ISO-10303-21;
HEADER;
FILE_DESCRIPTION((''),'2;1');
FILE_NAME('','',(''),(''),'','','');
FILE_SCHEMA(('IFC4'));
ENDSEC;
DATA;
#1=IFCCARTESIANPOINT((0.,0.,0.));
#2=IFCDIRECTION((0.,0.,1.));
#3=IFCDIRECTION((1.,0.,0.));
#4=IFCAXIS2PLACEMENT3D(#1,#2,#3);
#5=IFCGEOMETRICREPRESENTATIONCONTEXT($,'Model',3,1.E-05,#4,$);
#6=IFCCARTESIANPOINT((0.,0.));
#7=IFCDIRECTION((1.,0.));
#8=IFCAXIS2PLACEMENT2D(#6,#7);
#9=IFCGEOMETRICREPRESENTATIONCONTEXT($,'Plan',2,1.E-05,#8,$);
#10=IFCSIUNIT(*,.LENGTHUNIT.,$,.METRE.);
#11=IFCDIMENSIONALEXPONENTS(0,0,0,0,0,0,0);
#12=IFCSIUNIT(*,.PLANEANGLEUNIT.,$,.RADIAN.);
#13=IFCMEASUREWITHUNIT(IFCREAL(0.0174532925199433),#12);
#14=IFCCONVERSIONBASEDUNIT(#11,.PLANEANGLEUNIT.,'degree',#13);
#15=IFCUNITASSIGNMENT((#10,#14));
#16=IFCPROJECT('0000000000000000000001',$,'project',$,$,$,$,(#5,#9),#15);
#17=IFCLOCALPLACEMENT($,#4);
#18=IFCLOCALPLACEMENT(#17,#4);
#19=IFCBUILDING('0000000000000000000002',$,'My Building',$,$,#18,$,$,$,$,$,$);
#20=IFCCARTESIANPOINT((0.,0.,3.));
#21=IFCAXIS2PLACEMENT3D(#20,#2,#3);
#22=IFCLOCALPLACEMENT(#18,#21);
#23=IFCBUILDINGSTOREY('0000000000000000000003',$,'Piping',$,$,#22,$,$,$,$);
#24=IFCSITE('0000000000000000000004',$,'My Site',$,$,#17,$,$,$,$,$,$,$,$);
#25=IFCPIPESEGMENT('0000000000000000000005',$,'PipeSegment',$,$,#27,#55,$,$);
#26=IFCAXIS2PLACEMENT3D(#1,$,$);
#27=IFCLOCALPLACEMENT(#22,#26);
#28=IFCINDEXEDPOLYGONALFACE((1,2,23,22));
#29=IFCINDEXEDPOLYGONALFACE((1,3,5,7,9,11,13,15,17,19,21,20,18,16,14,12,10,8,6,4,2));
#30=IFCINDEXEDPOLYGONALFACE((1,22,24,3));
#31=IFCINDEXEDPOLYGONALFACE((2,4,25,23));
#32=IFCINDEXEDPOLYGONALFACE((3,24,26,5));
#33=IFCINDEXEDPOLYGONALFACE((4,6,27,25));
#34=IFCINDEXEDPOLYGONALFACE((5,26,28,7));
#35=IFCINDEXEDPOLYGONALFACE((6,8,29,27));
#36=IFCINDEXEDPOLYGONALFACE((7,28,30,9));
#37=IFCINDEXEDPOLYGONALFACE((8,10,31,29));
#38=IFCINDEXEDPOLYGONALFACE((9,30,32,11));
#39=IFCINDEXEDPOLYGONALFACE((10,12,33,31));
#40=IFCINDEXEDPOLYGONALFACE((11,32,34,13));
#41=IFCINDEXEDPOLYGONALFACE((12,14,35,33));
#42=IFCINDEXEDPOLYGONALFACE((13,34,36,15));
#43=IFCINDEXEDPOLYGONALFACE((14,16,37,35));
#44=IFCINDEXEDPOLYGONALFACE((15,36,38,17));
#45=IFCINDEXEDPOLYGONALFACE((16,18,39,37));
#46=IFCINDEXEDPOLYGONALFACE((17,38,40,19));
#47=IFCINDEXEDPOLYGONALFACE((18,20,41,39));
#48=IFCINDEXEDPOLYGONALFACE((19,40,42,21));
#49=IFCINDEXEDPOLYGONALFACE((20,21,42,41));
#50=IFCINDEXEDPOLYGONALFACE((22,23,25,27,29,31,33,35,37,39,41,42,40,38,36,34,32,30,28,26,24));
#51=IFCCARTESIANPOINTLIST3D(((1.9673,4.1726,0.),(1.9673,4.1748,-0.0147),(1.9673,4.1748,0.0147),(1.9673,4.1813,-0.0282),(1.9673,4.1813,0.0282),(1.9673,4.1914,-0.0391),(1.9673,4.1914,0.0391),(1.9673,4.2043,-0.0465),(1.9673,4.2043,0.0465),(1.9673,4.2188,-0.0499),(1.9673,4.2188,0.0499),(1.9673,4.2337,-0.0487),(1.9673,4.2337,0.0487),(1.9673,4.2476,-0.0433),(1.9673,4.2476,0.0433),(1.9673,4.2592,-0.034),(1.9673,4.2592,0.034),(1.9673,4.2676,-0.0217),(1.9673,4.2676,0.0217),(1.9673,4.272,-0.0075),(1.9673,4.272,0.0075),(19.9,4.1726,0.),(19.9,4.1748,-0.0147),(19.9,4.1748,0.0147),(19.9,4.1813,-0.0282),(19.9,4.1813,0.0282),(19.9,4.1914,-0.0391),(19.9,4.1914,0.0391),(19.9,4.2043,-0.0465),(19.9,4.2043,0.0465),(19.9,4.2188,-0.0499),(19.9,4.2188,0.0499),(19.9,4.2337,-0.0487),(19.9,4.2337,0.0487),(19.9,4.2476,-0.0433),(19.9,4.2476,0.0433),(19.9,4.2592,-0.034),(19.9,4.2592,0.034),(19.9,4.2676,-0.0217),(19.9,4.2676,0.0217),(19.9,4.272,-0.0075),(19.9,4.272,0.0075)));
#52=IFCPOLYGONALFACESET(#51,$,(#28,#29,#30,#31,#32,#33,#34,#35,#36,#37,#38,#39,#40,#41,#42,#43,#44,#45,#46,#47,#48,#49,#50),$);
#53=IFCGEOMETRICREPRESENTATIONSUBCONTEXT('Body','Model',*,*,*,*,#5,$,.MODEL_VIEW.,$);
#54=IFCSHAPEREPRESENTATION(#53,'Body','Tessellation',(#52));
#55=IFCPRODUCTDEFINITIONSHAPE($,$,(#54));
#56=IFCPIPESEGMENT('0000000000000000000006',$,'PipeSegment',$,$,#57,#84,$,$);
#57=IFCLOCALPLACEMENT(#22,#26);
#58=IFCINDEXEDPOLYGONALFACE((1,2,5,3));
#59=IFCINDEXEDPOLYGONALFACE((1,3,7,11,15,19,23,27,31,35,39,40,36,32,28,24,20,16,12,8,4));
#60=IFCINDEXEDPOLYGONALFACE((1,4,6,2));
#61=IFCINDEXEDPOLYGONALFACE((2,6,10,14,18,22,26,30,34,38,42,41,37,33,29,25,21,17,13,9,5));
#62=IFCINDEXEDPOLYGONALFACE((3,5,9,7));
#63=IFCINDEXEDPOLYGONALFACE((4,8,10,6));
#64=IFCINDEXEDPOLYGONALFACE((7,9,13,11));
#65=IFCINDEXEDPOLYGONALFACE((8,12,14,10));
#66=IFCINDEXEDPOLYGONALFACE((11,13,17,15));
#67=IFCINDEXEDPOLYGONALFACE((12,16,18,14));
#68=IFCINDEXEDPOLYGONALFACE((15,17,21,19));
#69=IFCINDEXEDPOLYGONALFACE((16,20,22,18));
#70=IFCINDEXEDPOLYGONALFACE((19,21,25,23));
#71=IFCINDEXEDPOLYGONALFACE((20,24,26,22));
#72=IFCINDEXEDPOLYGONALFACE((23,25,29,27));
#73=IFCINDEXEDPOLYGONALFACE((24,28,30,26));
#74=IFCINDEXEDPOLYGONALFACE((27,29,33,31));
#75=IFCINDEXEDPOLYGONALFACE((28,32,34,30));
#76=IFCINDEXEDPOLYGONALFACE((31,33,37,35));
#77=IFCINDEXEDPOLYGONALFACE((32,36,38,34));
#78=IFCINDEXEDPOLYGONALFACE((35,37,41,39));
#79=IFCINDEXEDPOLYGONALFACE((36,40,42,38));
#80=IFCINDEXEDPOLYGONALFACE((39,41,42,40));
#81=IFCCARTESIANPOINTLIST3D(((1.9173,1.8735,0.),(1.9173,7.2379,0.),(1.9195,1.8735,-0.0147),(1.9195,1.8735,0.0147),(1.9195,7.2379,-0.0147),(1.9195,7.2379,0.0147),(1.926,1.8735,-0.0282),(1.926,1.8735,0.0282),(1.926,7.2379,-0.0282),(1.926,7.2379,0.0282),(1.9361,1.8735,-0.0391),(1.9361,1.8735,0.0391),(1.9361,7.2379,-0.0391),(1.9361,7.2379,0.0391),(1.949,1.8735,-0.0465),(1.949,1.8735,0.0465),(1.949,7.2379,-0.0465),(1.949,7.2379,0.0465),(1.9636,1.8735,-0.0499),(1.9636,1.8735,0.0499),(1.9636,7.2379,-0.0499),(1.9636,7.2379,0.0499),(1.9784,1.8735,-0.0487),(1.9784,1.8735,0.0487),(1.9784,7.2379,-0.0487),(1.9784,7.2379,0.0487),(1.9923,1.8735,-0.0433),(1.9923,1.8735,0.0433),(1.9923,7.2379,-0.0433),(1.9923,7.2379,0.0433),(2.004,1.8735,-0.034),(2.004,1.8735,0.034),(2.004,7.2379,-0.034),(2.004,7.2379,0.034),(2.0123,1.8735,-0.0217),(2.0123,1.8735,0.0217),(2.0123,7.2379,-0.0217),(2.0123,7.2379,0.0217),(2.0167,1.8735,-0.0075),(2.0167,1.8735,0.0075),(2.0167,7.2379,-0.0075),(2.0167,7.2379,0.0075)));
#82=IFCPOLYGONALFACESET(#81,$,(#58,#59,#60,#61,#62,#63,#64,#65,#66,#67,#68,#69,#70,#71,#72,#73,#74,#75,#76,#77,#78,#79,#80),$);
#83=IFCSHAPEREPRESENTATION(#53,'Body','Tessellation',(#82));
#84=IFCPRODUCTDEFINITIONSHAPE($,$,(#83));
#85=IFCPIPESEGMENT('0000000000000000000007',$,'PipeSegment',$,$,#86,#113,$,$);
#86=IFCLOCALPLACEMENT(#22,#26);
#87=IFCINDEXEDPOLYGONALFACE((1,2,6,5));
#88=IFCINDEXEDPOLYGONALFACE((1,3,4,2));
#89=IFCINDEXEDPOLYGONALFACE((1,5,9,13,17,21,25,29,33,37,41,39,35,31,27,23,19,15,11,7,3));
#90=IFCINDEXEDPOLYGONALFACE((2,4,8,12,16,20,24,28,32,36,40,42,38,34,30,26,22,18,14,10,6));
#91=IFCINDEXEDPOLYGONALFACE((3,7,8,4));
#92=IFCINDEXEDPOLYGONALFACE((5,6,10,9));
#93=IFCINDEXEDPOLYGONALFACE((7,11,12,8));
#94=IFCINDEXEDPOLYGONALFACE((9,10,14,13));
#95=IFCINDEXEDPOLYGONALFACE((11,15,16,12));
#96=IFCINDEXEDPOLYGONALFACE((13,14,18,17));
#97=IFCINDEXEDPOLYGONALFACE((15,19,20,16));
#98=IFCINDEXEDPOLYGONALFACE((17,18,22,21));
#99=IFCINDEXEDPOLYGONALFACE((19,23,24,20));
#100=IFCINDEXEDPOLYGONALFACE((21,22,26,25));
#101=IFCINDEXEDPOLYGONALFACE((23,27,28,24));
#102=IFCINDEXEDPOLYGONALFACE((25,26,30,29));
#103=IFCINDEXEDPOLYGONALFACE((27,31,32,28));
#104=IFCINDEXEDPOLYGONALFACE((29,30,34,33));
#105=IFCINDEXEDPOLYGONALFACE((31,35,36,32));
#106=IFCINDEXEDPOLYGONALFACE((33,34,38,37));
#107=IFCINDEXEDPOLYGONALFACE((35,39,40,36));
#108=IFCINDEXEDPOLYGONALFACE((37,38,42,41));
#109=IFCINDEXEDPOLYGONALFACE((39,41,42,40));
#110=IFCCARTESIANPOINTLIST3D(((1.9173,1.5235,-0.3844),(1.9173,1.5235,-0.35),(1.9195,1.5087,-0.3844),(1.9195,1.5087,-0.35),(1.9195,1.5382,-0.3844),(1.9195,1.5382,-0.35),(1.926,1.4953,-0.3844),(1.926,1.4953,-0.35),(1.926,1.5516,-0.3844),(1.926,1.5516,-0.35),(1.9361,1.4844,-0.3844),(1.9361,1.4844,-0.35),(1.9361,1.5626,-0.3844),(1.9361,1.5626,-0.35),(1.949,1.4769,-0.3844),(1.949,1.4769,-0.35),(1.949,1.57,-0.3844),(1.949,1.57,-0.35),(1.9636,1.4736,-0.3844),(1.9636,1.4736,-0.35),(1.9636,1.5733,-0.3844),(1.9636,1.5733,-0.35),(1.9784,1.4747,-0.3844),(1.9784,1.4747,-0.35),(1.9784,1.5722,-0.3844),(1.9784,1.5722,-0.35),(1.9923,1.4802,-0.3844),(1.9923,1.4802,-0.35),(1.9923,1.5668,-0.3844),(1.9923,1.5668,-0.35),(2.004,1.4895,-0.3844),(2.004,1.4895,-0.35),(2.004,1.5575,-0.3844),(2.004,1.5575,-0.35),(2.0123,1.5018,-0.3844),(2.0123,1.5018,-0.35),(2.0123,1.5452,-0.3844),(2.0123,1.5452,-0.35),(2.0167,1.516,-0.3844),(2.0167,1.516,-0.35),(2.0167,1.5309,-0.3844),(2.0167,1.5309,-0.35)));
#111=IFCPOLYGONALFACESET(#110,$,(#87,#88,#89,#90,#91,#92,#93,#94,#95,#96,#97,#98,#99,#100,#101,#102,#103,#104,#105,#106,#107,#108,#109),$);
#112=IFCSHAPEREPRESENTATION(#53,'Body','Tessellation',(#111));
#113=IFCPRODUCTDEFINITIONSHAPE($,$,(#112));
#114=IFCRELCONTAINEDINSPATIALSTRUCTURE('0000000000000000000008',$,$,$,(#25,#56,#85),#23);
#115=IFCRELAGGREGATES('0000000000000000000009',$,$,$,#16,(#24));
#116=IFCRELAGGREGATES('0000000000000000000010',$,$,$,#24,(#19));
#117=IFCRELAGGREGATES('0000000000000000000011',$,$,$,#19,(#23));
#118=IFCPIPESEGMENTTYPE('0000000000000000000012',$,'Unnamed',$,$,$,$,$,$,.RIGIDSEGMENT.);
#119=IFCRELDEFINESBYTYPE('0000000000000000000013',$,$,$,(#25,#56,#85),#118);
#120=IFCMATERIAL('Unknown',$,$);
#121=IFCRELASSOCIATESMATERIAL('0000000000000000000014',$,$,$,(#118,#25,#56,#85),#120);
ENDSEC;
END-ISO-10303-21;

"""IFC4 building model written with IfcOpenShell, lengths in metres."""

from ifc_helpers import new_model, entity, si_unit, converted_unit, frame, origin_with_axes, origin_2d_with_axis, place, context, subcontext, project, spatial, circle, extrude, material, material_profile, profile_set, profile_usage, type_object, element, save


model = new_model("IFC4")

# Units and contexts
model_context = context("Model", 3, precision=1e-05, world=origin_with_axes())
plan_context = context("Plan", 2, precision=1e-05, world=origin_2d_with_axis())
body_context = subcontext(model_context, "Body", "Model", "MODEL_VIEW")
ifc_project = project(units=[si_unit("LENGTHUNIT", "METRE"), converted_unit("PLANEANGLEUNIT", "degree", entity("IfcReal", 0.0174532925199433), si_unit("PLANEANGLEUNIT", "RADIAN"), dimensions=[0, 0, 0, 0, 0, 0, 0])], contexts=[model_context, plan_context])

# Site, building, storey
site_placement = place(None, origin_with_axes())
site = spatial("IfcSite", under=ifc_project, at=site_placement, Name="My Site")
building_placement = place(site_placement, origin_with_axes())
building = spatial("IfcBuilding", under=site, at=building_placement, Name="My Building")
storey_placement = place(building_placement, frame((0.0, 0.0, 3.0), z_axis=(0.0, 0.0, 1.0), x_axis=(1.0, 0.0, 0.0)))
storey = spatial("IfcBuildingStorey", under=building, at=storey_placement, Name="Piping")

# Pipe segments
ifc_material = material(Name="Unknown")
ifc_material_profile = material_profile(ifc_material, circle(Radius=0.05))
ifc_profile_set = profile_set([ifc_material_profile])
ifc_profile_usage_1 = profile_usage(ifc_profile_set, cardinal=5)
pipe_segment_type = type_object("IfcPipeSegmentType", Name="Unnamed", PredefinedType="RIGIDSEGMENT", material=ifc_profile_set)
pipe_segment_1_placement = place(storey_placement, frame((19.9, 4.2226, 0.0), z_axis=(-1.0, 0.0, 0.0), x_axis=(0.0, -1.0, 0.0)))
element("IfcPipeSegment", 1, at=pipe_segment_1_placement, inside=storey, type_object=pipe_segment_type, material=ifc_profile_usage_1, Name="PipeSegment", context=body_context, shape_type="SweptSolid", body=[
    extrude(circle(Radius=0.05), origin_with_axes(), (0.0, 0.0, 1.0), 17.9327),
])
ifc_profile_usage_2 = profile_usage(ifc_profile_set, cardinal=5)
pipe_segment_2_placement = place(storey_placement, frame((1.9673, 1.8735, 0.0), z_axis=(0.0, 1.0, 0.0), x_axis=(-1.0, 0.0, 0.0)))
element("IfcPipeSegment", 2, at=pipe_segment_2_placement, inside=storey, type_object=pipe_segment_type, material=ifc_profile_usage_2, Name="PipeSegment", context=body_context, shape_type="SweptSolid", body=[
    extrude(circle(Radius=0.05), origin_with_axes(), (0.0, 0.0, 1.0), 5.3645),
])
ifc_profile_usage_3 = profile_usage(ifc_profile_set, cardinal=5)
pipe_segment_3_placement = place(storey_placement, frame((1.9673, 1.5235, -0.35), z_axis=(0.0, 0.0, -1.0), x_axis=(-1.0, 0.0, 0.0)))
element("IfcPipeSegment", 3, at=pipe_segment_3_placement, inside=storey, type_object=pipe_segment_type, material=ifc_profile_usage_3, Name="PipeSegment", context=body_context, shape_type="SweptSolid", body=[
    extrude(circle(Radius=0.05), origin_with_axes(), (0.0, 0.0, 1.0), 0.0344),
])

save(model, "model.ifc")
